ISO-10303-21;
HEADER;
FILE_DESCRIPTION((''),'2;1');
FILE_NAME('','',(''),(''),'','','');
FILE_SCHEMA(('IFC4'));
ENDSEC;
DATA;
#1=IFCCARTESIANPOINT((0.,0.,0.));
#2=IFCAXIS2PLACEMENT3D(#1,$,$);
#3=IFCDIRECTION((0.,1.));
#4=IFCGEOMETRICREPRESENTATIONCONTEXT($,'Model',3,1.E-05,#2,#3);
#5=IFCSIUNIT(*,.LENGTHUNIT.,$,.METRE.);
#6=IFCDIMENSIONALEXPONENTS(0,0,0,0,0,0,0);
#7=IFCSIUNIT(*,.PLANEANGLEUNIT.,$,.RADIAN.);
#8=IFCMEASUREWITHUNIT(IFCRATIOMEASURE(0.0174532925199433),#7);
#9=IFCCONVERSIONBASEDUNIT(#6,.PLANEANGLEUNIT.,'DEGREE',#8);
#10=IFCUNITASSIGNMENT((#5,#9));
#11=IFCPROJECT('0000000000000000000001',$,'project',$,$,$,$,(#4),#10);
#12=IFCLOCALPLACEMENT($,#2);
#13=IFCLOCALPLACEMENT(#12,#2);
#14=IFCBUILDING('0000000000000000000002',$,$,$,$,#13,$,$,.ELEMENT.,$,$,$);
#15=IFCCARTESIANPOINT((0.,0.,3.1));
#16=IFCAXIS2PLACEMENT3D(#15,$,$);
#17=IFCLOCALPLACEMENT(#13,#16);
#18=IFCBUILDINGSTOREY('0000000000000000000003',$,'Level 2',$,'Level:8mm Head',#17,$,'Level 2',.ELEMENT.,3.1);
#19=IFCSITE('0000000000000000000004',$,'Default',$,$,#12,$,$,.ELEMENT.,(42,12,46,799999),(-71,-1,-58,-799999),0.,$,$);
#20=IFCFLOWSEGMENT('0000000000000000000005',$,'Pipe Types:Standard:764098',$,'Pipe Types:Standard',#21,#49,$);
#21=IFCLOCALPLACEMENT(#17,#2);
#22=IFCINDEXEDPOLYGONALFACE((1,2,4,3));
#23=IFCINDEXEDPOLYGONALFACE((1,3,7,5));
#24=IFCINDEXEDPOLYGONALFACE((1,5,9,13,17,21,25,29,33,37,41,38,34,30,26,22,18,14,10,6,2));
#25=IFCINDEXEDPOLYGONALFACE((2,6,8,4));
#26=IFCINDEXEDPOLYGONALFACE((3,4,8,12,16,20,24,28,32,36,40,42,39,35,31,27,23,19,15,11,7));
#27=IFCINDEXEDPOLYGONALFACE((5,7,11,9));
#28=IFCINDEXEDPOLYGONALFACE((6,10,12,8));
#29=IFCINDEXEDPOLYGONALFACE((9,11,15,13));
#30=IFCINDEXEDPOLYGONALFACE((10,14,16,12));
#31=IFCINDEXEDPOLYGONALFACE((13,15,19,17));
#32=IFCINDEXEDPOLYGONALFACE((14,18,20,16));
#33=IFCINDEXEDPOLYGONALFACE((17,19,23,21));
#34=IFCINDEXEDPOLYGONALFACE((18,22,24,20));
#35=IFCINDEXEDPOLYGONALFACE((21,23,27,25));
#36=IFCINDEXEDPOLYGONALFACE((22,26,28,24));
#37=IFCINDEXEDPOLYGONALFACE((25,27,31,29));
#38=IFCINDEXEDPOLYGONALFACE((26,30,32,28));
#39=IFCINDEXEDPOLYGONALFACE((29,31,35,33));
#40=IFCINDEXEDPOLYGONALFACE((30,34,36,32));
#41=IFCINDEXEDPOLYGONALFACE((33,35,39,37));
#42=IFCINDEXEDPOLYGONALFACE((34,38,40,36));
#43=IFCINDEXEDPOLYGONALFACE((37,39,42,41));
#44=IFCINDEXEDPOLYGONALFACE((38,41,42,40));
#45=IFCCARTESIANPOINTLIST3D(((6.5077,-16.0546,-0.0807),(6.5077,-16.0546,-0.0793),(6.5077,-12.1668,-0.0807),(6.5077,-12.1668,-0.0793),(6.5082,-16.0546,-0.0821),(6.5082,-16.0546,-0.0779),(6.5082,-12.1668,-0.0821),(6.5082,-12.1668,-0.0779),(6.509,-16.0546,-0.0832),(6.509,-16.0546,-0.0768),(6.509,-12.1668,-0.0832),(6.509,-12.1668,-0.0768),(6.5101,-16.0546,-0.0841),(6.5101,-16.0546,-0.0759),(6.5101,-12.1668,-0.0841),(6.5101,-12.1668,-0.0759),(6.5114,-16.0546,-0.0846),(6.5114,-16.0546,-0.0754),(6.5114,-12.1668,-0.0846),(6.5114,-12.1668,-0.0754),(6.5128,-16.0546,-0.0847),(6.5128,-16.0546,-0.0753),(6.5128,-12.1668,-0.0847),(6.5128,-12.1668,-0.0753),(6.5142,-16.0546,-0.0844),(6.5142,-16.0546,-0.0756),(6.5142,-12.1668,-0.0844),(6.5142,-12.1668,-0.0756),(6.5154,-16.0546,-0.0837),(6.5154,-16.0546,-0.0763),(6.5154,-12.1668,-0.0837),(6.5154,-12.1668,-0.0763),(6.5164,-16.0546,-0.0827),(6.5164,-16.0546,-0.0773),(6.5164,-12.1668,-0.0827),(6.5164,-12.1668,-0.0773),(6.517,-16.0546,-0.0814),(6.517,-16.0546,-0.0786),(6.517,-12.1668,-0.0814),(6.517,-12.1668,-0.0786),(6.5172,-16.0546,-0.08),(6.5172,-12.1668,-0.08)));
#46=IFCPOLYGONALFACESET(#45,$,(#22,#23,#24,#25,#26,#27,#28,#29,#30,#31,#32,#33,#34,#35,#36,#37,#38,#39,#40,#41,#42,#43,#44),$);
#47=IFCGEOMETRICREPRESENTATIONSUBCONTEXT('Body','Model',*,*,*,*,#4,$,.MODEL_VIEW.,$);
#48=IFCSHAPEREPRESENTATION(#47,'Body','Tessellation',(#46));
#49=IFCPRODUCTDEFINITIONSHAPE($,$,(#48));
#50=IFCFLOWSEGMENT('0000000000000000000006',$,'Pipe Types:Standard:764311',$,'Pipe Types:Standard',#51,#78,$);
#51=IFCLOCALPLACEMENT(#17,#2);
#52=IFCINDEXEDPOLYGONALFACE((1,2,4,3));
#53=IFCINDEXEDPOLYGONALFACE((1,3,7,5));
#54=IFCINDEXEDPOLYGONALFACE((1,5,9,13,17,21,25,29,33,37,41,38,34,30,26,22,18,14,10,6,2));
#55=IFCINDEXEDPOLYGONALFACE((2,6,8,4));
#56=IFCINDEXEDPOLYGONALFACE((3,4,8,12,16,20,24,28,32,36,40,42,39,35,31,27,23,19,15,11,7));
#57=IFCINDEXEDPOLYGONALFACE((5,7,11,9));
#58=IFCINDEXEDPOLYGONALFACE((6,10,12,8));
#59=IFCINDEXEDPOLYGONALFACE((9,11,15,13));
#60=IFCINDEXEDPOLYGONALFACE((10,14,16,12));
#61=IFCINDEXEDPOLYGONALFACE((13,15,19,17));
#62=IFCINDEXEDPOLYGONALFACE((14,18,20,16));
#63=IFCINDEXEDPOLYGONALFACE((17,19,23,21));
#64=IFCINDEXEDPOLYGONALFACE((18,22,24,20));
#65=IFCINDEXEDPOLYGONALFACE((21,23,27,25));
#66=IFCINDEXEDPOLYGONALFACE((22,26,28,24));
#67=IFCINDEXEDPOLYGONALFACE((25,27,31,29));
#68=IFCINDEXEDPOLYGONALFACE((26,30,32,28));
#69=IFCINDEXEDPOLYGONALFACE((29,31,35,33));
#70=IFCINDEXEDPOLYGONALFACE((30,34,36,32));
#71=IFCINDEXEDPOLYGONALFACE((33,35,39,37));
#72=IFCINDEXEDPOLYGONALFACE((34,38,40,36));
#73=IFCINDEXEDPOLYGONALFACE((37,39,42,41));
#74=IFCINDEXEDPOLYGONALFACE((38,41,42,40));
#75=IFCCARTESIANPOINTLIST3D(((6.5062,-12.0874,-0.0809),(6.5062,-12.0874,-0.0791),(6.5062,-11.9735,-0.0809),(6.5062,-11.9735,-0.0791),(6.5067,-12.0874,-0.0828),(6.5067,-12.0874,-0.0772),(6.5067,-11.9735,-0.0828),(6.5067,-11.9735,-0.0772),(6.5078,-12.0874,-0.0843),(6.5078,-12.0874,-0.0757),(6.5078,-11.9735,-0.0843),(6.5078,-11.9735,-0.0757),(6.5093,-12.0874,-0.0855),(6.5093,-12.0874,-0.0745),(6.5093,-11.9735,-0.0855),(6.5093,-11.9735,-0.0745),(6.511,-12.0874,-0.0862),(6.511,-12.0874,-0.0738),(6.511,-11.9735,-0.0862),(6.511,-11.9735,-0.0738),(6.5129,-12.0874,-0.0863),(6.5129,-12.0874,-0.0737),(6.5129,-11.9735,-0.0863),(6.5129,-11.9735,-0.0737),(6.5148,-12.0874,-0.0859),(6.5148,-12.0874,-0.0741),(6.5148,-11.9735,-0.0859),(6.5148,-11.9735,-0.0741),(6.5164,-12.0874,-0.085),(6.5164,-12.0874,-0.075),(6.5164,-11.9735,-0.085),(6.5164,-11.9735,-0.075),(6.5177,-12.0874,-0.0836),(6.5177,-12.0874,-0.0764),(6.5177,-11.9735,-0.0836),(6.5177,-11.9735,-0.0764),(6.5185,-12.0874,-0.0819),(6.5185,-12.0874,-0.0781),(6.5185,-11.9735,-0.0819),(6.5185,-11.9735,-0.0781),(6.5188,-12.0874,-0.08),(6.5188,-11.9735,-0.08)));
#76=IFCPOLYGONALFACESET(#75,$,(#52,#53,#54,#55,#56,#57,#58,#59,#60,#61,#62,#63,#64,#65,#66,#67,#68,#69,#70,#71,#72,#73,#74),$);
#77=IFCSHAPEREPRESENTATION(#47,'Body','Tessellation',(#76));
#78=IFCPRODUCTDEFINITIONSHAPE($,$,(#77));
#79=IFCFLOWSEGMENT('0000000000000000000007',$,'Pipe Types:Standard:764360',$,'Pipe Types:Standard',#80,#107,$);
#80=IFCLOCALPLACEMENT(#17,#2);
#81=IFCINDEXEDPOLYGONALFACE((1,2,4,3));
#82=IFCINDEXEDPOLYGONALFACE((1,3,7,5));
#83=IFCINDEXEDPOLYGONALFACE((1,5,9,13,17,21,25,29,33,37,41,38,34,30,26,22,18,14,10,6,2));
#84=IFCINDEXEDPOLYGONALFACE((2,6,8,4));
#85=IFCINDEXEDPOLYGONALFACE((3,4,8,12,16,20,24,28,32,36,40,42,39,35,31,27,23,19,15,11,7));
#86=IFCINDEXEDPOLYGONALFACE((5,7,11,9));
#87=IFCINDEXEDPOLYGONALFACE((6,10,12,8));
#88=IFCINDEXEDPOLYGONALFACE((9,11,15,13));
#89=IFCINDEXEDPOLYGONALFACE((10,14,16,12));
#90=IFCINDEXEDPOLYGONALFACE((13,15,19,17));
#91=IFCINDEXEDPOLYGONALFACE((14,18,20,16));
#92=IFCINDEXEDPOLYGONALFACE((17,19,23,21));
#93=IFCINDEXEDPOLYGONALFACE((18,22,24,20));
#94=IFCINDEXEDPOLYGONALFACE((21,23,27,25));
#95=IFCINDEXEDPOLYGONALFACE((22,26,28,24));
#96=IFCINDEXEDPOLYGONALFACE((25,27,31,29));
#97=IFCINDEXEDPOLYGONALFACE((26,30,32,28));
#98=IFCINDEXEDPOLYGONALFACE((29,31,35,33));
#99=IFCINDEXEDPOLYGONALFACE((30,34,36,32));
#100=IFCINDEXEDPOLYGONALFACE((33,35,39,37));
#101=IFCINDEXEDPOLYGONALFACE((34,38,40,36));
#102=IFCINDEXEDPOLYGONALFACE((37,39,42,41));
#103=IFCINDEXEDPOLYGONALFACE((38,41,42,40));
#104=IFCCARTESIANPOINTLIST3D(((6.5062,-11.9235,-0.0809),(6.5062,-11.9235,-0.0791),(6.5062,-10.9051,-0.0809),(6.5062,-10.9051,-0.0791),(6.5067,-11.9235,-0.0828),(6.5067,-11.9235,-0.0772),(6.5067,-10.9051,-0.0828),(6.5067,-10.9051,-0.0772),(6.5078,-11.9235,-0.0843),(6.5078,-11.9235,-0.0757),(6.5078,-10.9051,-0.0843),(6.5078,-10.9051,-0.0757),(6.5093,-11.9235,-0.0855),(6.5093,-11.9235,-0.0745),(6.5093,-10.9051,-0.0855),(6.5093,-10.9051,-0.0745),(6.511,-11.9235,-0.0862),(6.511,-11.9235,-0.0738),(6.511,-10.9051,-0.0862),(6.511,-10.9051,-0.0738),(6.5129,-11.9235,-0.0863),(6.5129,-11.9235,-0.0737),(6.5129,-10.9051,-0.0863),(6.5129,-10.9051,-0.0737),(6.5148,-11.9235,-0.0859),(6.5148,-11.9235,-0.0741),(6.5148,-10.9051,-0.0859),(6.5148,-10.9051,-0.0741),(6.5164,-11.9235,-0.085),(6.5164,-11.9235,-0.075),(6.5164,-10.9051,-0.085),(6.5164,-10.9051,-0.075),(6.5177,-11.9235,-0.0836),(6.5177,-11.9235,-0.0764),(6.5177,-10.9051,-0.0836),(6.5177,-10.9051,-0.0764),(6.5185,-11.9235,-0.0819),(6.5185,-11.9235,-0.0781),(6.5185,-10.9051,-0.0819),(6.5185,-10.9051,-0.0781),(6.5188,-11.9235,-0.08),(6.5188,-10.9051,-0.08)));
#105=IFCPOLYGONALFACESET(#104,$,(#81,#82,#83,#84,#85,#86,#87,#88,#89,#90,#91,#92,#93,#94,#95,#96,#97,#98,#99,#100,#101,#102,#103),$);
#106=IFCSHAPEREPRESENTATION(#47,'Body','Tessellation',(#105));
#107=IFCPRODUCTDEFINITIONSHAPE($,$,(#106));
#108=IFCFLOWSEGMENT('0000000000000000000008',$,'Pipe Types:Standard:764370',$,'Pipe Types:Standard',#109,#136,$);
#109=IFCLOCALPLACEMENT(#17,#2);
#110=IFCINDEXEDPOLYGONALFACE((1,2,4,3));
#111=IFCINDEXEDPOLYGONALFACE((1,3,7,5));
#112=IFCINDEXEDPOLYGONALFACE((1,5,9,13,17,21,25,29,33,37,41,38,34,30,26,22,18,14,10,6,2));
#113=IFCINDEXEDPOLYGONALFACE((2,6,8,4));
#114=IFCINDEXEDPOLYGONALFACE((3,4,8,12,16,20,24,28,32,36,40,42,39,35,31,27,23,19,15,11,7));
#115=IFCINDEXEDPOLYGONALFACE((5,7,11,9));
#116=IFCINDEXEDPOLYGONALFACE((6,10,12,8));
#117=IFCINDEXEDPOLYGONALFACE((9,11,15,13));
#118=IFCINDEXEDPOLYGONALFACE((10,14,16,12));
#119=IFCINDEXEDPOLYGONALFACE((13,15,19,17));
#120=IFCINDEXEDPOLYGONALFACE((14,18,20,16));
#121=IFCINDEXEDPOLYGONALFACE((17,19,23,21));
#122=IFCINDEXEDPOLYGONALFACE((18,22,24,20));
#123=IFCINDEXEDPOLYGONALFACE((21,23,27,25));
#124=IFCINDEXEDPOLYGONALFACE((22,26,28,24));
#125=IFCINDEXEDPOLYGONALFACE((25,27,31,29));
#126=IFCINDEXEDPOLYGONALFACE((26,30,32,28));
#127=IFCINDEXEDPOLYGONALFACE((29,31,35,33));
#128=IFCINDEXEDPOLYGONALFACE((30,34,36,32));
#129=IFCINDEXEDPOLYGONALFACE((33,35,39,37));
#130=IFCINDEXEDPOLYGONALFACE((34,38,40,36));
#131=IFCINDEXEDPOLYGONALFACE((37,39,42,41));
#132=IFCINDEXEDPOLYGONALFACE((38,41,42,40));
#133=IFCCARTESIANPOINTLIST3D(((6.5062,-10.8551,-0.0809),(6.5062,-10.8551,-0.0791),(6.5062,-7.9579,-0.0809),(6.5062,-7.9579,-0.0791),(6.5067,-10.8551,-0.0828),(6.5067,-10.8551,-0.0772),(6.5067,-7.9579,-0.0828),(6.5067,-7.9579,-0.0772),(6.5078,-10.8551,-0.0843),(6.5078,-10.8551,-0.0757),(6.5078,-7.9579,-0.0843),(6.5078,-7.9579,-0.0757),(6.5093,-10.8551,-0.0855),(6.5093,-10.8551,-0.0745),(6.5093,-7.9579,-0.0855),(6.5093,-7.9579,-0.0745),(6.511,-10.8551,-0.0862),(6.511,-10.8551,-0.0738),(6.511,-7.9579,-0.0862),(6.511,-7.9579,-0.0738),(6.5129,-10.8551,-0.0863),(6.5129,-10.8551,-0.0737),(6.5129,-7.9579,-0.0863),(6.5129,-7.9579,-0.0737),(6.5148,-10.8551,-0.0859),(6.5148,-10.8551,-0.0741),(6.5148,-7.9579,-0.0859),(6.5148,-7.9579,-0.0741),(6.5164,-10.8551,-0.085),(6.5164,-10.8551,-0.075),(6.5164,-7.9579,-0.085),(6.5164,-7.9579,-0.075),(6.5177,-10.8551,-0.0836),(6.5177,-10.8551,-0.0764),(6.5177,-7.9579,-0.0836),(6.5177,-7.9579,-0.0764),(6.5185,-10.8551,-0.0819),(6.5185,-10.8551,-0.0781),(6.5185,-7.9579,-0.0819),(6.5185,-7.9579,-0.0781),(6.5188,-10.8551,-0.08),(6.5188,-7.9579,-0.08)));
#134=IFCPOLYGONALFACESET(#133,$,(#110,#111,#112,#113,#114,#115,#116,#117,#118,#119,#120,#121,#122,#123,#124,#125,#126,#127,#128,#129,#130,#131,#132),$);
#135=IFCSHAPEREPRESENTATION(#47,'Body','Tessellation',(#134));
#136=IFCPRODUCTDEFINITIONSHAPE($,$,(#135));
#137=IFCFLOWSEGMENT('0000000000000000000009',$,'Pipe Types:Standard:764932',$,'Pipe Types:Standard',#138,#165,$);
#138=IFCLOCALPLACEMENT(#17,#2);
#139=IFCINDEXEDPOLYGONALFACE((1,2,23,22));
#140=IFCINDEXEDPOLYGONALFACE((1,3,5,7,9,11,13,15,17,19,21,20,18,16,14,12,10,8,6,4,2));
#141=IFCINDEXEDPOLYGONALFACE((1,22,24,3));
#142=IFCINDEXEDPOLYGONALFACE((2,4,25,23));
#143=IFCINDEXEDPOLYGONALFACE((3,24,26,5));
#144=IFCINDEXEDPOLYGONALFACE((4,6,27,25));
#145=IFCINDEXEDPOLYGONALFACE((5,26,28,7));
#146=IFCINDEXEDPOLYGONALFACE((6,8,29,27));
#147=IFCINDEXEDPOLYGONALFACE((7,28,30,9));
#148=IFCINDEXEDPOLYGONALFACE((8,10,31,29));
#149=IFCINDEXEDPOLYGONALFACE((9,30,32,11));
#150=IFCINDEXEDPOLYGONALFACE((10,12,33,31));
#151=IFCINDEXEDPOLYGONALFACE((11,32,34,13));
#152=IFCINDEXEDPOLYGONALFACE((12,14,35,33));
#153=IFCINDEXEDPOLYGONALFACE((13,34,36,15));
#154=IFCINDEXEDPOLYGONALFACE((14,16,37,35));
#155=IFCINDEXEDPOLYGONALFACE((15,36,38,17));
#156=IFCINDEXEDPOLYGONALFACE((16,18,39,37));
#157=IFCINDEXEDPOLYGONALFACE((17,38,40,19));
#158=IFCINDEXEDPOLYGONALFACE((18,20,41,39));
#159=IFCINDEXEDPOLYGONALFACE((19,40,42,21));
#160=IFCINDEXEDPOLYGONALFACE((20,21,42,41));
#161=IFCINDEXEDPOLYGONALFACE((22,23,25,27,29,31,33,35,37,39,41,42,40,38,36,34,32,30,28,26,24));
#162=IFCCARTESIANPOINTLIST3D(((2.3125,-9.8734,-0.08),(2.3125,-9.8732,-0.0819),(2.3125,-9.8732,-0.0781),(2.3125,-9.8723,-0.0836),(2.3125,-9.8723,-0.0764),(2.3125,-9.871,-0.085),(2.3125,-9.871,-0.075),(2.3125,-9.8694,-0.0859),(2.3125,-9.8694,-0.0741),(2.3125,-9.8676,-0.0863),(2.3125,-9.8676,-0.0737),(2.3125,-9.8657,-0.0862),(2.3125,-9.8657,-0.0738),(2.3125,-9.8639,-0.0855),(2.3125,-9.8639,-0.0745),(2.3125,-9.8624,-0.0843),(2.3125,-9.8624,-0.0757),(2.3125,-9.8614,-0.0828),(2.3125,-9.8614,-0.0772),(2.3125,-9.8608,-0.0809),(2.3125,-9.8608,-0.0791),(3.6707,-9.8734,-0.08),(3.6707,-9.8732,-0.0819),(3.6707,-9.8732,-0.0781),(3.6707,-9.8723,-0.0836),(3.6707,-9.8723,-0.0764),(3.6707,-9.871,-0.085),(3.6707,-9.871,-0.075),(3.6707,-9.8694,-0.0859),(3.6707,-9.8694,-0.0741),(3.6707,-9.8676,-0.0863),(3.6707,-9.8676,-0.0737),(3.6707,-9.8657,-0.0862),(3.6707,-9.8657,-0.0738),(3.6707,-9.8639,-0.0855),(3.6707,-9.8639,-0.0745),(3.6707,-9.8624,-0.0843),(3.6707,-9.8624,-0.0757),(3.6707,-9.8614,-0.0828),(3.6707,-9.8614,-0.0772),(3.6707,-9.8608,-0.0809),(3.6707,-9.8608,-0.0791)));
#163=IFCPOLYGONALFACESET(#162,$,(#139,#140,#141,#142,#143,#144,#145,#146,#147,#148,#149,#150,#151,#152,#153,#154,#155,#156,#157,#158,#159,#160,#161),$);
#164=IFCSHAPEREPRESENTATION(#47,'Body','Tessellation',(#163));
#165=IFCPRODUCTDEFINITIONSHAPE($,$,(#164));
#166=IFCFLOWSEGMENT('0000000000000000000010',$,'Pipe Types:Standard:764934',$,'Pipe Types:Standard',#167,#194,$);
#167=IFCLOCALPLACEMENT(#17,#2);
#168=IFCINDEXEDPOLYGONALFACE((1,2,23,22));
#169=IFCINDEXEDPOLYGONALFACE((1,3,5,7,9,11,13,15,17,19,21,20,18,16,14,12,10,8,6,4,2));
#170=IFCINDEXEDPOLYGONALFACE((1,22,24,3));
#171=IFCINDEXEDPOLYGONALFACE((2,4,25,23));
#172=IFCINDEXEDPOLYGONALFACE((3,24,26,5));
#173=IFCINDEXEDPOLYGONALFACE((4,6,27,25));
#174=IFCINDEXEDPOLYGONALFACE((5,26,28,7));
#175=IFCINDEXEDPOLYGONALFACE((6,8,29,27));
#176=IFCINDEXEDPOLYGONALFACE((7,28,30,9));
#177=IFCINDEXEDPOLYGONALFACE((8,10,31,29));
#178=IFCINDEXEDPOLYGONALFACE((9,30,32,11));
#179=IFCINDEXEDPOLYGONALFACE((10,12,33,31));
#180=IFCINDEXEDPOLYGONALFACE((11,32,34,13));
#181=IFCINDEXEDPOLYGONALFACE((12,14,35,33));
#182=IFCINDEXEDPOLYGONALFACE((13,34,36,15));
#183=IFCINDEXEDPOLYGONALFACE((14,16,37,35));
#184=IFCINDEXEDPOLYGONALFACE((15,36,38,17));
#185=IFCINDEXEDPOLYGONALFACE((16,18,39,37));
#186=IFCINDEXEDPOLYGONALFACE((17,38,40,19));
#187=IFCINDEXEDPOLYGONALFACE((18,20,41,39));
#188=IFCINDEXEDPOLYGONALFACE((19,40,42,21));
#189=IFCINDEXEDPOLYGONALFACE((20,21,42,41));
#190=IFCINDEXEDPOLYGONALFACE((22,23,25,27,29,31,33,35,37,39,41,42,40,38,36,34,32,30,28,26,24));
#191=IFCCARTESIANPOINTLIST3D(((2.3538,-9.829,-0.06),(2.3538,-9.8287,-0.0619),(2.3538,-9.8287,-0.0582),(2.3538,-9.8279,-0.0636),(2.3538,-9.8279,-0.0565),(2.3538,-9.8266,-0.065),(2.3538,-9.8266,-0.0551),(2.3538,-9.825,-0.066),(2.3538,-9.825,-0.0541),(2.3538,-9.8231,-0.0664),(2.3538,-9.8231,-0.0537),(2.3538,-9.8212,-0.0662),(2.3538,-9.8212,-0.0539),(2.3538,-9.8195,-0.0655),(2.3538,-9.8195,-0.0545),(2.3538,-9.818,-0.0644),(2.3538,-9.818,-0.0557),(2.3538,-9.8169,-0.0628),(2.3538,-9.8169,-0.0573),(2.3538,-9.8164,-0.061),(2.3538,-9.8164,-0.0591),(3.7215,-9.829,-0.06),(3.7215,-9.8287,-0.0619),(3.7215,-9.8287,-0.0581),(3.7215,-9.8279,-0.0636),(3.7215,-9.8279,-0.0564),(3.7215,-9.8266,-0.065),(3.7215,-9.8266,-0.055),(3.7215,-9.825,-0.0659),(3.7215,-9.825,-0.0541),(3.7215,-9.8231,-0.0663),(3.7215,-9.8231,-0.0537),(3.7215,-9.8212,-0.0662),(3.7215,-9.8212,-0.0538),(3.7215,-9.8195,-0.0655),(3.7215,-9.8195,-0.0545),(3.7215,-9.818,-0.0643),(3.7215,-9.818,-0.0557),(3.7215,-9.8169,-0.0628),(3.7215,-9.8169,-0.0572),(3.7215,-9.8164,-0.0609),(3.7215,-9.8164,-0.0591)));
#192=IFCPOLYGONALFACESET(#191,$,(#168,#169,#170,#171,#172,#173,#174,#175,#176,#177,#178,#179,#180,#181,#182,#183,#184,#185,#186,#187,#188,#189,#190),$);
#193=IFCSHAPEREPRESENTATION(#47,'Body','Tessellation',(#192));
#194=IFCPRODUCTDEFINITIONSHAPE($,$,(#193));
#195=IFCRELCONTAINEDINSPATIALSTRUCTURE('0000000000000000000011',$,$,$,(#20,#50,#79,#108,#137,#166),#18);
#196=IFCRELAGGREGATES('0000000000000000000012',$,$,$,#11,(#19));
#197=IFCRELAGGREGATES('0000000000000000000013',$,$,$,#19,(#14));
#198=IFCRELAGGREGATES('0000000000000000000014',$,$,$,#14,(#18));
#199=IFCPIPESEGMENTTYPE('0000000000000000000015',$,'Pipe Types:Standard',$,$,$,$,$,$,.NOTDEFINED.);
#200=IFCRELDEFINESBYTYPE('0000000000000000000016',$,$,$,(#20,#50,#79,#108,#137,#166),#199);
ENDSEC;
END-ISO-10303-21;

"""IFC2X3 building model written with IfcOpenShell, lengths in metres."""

from ifc_helpers import new_model, entity, si_unit, converted_unit, direction, frame, frame_2d, origin, origin_2d_with_axis, place, context, subcontext, project, spatial, circle, extrude, type_object, element, save


model = new_model("IFC2X3")

# Units and contexts
model_context = context("Model", 3, precision=1e-05, world=origin(), true_north=direction((0.0, 1.0)))
body_context = subcontext(model_context, "Body", "Model", "MODEL_VIEW")
ifc_project = project(units=[si_unit("LENGTHUNIT", "METRE"), converted_unit("PLANEANGLEUNIT", "DEGREE", entity("IfcRatioMeasure", 0.0174532925199433), si_unit("PLANEANGLEUNIT", "RADIAN"), dimensions=[0, 0, 0, 0, 0, 0, 0])], contexts=[model_context])

# Site, building, storey
site_placement = place(None, origin())
site = spatial("IfcSite", under=ifc_project, at=site_placement, Name="Default", CompositionType="ELEMENT", RefLatitude=(42, 12, 46, 799999), RefLongitude=(-71, -1, -58, -799999), RefElevation=0.0)
building_placement = place(site_placement, origin())
building = spatial("IfcBuilding", under=site, at=building_placement, CompositionType="ELEMENT")
storey_placement = place(building_placement, frame((0.0, 0.0, 3.1)))
storey = spatial("IfcBuildingStorey", under=building, at=storey_placement, Name="Level 2", ObjectType="Level:8mm Head", LongName="Level 2", CompositionType="ELEMENT", Elevation=3.1)

# Flow segments
pipe_segment_type = type_object("IfcPipeSegmentType", Name="Pipe Types:Standard", PredefinedType="NOTDEFINED")
flow_segment_1_placement = place(storey_placement, origin())
element("IfcFlowSegment", 1, at=flow_segment_1_placement, inside=storey, type_object=pipe_segment_type, Name="Pipe Types:Standard:764098", ObjectType="Pipe Types:Standard", context=body_context, shape_type="SweptSolid", body=[
    extrude(circle(Radius=0.0048, at=origin_2d_with_axis()), frame((6.5125, -16.0546, -0.08), z_axis=(0.0, 1.0, 0.0), x_axis=(1.0, 0.0, 0.0)), (0.0, 0.0, 1.0), 3.8877),
])
flow_segment_2_placement = place(storey_placement, origin())
element("IfcFlowSegment", 2, at=flow_segment_2_placement, inside=storey, type_object=pipe_segment_type, Name="Pipe Types:Standard:764311", ObjectType="Pipe Types:Standard", context=body_context, shape_type="SweptSolid", body=[
    extrude(circle(Radius=0.0063, at=frame_2d((0.0, 0.0), x_axis=(1.0, 0.0))), frame((6.5125, -12.0874, -0.08), z_axis=(0.0, 1.0, 0.0), x_axis=(1.0, 0.0, 0.0)), (0.0, 0.0, 1.0), 0.1139),
])
flow_segment_3_placement = place(storey_placement, origin())
element("IfcFlowSegment", 3, at=flow_segment_3_placement, inside=storey, type_object=pipe_segment_type, Name="Pipe Types:Standard:764360", ObjectType="Pipe Types:Standard", context=body_context, shape_type="SweptSolid", body=[
    extrude(circle(Radius=0.0063, at=frame_2d((0.0, 0.0), x_axis=(1.0, 0.0))), frame((6.5125, -11.9235, -0.08), z_axis=(0.0, 1.0, 0.0), x_axis=(1.0, 0.0, 0.0)), (0.0, 0.0, 1.0), 1.0184),
])
flow_segment_4_placement = place(storey_placement, origin())
element("IfcFlowSegment", 4, at=flow_segment_4_placement, inside=storey, type_object=pipe_segment_type, Name="Pipe Types:Standard:764370", ObjectType="Pipe Types:Standard", context=body_context, shape_type="SweptSolid", body=[
    extrude(circle(Radius=0.0063, at=frame_2d((0.0, 0.0), x_axis=(1.0, 0.0))), frame((6.5125, -10.8551, -0.08), z_axis=(0.0, 1.0, 0.0), x_axis=(1.0, 0.0, 0.0)), (0.0, 0.0, 1.0), 2.8971),
])
flow_segment_5_placement = place(storey_placement, origin())
element("IfcFlowSegment", 5, at=flow_segment_5_placement, inside=storey, type_object=pipe_segment_type, Name="Pipe Types:Standard:764932", ObjectType="Pipe Types:Standard", context=body_context, shape_type="SweptSolid", body=[
    extrude(circle(Radius=0.0063, at=origin_2d_with_axis()), frame((2.3125, -9.8671, -0.08), z_axis=(1.0, 0.0, 0.0), x_axis=(0.0, -1.0, 0.0)), (0.0, 0.0, 1.0), 1.3582),
])
flow_segment_6_placement = place(storey_placement, origin())
element("IfcFlowSegment", 6, at=flow_segment_6_placement, inside=storey, type_object=pipe_segment_type, Name="Pipe Types:Standard:764934", ObjectType="Pipe Types:Standard", context=body_context, shape_type="SweptSolid", body=[
    extrude(circle(Radius=0.0063, at=frame_2d((0.0, 0.0), x_axis=(1.0, 0.0))), frame((2.3538, -9.8226, -0.06), z_axis=(1.0, 0.0, 0.000032), x_axis=(0.0, -1.0, 0.0)), (0.0, 0.0, 1.0), 1.3677),
])

save(model, "model.ifc")
